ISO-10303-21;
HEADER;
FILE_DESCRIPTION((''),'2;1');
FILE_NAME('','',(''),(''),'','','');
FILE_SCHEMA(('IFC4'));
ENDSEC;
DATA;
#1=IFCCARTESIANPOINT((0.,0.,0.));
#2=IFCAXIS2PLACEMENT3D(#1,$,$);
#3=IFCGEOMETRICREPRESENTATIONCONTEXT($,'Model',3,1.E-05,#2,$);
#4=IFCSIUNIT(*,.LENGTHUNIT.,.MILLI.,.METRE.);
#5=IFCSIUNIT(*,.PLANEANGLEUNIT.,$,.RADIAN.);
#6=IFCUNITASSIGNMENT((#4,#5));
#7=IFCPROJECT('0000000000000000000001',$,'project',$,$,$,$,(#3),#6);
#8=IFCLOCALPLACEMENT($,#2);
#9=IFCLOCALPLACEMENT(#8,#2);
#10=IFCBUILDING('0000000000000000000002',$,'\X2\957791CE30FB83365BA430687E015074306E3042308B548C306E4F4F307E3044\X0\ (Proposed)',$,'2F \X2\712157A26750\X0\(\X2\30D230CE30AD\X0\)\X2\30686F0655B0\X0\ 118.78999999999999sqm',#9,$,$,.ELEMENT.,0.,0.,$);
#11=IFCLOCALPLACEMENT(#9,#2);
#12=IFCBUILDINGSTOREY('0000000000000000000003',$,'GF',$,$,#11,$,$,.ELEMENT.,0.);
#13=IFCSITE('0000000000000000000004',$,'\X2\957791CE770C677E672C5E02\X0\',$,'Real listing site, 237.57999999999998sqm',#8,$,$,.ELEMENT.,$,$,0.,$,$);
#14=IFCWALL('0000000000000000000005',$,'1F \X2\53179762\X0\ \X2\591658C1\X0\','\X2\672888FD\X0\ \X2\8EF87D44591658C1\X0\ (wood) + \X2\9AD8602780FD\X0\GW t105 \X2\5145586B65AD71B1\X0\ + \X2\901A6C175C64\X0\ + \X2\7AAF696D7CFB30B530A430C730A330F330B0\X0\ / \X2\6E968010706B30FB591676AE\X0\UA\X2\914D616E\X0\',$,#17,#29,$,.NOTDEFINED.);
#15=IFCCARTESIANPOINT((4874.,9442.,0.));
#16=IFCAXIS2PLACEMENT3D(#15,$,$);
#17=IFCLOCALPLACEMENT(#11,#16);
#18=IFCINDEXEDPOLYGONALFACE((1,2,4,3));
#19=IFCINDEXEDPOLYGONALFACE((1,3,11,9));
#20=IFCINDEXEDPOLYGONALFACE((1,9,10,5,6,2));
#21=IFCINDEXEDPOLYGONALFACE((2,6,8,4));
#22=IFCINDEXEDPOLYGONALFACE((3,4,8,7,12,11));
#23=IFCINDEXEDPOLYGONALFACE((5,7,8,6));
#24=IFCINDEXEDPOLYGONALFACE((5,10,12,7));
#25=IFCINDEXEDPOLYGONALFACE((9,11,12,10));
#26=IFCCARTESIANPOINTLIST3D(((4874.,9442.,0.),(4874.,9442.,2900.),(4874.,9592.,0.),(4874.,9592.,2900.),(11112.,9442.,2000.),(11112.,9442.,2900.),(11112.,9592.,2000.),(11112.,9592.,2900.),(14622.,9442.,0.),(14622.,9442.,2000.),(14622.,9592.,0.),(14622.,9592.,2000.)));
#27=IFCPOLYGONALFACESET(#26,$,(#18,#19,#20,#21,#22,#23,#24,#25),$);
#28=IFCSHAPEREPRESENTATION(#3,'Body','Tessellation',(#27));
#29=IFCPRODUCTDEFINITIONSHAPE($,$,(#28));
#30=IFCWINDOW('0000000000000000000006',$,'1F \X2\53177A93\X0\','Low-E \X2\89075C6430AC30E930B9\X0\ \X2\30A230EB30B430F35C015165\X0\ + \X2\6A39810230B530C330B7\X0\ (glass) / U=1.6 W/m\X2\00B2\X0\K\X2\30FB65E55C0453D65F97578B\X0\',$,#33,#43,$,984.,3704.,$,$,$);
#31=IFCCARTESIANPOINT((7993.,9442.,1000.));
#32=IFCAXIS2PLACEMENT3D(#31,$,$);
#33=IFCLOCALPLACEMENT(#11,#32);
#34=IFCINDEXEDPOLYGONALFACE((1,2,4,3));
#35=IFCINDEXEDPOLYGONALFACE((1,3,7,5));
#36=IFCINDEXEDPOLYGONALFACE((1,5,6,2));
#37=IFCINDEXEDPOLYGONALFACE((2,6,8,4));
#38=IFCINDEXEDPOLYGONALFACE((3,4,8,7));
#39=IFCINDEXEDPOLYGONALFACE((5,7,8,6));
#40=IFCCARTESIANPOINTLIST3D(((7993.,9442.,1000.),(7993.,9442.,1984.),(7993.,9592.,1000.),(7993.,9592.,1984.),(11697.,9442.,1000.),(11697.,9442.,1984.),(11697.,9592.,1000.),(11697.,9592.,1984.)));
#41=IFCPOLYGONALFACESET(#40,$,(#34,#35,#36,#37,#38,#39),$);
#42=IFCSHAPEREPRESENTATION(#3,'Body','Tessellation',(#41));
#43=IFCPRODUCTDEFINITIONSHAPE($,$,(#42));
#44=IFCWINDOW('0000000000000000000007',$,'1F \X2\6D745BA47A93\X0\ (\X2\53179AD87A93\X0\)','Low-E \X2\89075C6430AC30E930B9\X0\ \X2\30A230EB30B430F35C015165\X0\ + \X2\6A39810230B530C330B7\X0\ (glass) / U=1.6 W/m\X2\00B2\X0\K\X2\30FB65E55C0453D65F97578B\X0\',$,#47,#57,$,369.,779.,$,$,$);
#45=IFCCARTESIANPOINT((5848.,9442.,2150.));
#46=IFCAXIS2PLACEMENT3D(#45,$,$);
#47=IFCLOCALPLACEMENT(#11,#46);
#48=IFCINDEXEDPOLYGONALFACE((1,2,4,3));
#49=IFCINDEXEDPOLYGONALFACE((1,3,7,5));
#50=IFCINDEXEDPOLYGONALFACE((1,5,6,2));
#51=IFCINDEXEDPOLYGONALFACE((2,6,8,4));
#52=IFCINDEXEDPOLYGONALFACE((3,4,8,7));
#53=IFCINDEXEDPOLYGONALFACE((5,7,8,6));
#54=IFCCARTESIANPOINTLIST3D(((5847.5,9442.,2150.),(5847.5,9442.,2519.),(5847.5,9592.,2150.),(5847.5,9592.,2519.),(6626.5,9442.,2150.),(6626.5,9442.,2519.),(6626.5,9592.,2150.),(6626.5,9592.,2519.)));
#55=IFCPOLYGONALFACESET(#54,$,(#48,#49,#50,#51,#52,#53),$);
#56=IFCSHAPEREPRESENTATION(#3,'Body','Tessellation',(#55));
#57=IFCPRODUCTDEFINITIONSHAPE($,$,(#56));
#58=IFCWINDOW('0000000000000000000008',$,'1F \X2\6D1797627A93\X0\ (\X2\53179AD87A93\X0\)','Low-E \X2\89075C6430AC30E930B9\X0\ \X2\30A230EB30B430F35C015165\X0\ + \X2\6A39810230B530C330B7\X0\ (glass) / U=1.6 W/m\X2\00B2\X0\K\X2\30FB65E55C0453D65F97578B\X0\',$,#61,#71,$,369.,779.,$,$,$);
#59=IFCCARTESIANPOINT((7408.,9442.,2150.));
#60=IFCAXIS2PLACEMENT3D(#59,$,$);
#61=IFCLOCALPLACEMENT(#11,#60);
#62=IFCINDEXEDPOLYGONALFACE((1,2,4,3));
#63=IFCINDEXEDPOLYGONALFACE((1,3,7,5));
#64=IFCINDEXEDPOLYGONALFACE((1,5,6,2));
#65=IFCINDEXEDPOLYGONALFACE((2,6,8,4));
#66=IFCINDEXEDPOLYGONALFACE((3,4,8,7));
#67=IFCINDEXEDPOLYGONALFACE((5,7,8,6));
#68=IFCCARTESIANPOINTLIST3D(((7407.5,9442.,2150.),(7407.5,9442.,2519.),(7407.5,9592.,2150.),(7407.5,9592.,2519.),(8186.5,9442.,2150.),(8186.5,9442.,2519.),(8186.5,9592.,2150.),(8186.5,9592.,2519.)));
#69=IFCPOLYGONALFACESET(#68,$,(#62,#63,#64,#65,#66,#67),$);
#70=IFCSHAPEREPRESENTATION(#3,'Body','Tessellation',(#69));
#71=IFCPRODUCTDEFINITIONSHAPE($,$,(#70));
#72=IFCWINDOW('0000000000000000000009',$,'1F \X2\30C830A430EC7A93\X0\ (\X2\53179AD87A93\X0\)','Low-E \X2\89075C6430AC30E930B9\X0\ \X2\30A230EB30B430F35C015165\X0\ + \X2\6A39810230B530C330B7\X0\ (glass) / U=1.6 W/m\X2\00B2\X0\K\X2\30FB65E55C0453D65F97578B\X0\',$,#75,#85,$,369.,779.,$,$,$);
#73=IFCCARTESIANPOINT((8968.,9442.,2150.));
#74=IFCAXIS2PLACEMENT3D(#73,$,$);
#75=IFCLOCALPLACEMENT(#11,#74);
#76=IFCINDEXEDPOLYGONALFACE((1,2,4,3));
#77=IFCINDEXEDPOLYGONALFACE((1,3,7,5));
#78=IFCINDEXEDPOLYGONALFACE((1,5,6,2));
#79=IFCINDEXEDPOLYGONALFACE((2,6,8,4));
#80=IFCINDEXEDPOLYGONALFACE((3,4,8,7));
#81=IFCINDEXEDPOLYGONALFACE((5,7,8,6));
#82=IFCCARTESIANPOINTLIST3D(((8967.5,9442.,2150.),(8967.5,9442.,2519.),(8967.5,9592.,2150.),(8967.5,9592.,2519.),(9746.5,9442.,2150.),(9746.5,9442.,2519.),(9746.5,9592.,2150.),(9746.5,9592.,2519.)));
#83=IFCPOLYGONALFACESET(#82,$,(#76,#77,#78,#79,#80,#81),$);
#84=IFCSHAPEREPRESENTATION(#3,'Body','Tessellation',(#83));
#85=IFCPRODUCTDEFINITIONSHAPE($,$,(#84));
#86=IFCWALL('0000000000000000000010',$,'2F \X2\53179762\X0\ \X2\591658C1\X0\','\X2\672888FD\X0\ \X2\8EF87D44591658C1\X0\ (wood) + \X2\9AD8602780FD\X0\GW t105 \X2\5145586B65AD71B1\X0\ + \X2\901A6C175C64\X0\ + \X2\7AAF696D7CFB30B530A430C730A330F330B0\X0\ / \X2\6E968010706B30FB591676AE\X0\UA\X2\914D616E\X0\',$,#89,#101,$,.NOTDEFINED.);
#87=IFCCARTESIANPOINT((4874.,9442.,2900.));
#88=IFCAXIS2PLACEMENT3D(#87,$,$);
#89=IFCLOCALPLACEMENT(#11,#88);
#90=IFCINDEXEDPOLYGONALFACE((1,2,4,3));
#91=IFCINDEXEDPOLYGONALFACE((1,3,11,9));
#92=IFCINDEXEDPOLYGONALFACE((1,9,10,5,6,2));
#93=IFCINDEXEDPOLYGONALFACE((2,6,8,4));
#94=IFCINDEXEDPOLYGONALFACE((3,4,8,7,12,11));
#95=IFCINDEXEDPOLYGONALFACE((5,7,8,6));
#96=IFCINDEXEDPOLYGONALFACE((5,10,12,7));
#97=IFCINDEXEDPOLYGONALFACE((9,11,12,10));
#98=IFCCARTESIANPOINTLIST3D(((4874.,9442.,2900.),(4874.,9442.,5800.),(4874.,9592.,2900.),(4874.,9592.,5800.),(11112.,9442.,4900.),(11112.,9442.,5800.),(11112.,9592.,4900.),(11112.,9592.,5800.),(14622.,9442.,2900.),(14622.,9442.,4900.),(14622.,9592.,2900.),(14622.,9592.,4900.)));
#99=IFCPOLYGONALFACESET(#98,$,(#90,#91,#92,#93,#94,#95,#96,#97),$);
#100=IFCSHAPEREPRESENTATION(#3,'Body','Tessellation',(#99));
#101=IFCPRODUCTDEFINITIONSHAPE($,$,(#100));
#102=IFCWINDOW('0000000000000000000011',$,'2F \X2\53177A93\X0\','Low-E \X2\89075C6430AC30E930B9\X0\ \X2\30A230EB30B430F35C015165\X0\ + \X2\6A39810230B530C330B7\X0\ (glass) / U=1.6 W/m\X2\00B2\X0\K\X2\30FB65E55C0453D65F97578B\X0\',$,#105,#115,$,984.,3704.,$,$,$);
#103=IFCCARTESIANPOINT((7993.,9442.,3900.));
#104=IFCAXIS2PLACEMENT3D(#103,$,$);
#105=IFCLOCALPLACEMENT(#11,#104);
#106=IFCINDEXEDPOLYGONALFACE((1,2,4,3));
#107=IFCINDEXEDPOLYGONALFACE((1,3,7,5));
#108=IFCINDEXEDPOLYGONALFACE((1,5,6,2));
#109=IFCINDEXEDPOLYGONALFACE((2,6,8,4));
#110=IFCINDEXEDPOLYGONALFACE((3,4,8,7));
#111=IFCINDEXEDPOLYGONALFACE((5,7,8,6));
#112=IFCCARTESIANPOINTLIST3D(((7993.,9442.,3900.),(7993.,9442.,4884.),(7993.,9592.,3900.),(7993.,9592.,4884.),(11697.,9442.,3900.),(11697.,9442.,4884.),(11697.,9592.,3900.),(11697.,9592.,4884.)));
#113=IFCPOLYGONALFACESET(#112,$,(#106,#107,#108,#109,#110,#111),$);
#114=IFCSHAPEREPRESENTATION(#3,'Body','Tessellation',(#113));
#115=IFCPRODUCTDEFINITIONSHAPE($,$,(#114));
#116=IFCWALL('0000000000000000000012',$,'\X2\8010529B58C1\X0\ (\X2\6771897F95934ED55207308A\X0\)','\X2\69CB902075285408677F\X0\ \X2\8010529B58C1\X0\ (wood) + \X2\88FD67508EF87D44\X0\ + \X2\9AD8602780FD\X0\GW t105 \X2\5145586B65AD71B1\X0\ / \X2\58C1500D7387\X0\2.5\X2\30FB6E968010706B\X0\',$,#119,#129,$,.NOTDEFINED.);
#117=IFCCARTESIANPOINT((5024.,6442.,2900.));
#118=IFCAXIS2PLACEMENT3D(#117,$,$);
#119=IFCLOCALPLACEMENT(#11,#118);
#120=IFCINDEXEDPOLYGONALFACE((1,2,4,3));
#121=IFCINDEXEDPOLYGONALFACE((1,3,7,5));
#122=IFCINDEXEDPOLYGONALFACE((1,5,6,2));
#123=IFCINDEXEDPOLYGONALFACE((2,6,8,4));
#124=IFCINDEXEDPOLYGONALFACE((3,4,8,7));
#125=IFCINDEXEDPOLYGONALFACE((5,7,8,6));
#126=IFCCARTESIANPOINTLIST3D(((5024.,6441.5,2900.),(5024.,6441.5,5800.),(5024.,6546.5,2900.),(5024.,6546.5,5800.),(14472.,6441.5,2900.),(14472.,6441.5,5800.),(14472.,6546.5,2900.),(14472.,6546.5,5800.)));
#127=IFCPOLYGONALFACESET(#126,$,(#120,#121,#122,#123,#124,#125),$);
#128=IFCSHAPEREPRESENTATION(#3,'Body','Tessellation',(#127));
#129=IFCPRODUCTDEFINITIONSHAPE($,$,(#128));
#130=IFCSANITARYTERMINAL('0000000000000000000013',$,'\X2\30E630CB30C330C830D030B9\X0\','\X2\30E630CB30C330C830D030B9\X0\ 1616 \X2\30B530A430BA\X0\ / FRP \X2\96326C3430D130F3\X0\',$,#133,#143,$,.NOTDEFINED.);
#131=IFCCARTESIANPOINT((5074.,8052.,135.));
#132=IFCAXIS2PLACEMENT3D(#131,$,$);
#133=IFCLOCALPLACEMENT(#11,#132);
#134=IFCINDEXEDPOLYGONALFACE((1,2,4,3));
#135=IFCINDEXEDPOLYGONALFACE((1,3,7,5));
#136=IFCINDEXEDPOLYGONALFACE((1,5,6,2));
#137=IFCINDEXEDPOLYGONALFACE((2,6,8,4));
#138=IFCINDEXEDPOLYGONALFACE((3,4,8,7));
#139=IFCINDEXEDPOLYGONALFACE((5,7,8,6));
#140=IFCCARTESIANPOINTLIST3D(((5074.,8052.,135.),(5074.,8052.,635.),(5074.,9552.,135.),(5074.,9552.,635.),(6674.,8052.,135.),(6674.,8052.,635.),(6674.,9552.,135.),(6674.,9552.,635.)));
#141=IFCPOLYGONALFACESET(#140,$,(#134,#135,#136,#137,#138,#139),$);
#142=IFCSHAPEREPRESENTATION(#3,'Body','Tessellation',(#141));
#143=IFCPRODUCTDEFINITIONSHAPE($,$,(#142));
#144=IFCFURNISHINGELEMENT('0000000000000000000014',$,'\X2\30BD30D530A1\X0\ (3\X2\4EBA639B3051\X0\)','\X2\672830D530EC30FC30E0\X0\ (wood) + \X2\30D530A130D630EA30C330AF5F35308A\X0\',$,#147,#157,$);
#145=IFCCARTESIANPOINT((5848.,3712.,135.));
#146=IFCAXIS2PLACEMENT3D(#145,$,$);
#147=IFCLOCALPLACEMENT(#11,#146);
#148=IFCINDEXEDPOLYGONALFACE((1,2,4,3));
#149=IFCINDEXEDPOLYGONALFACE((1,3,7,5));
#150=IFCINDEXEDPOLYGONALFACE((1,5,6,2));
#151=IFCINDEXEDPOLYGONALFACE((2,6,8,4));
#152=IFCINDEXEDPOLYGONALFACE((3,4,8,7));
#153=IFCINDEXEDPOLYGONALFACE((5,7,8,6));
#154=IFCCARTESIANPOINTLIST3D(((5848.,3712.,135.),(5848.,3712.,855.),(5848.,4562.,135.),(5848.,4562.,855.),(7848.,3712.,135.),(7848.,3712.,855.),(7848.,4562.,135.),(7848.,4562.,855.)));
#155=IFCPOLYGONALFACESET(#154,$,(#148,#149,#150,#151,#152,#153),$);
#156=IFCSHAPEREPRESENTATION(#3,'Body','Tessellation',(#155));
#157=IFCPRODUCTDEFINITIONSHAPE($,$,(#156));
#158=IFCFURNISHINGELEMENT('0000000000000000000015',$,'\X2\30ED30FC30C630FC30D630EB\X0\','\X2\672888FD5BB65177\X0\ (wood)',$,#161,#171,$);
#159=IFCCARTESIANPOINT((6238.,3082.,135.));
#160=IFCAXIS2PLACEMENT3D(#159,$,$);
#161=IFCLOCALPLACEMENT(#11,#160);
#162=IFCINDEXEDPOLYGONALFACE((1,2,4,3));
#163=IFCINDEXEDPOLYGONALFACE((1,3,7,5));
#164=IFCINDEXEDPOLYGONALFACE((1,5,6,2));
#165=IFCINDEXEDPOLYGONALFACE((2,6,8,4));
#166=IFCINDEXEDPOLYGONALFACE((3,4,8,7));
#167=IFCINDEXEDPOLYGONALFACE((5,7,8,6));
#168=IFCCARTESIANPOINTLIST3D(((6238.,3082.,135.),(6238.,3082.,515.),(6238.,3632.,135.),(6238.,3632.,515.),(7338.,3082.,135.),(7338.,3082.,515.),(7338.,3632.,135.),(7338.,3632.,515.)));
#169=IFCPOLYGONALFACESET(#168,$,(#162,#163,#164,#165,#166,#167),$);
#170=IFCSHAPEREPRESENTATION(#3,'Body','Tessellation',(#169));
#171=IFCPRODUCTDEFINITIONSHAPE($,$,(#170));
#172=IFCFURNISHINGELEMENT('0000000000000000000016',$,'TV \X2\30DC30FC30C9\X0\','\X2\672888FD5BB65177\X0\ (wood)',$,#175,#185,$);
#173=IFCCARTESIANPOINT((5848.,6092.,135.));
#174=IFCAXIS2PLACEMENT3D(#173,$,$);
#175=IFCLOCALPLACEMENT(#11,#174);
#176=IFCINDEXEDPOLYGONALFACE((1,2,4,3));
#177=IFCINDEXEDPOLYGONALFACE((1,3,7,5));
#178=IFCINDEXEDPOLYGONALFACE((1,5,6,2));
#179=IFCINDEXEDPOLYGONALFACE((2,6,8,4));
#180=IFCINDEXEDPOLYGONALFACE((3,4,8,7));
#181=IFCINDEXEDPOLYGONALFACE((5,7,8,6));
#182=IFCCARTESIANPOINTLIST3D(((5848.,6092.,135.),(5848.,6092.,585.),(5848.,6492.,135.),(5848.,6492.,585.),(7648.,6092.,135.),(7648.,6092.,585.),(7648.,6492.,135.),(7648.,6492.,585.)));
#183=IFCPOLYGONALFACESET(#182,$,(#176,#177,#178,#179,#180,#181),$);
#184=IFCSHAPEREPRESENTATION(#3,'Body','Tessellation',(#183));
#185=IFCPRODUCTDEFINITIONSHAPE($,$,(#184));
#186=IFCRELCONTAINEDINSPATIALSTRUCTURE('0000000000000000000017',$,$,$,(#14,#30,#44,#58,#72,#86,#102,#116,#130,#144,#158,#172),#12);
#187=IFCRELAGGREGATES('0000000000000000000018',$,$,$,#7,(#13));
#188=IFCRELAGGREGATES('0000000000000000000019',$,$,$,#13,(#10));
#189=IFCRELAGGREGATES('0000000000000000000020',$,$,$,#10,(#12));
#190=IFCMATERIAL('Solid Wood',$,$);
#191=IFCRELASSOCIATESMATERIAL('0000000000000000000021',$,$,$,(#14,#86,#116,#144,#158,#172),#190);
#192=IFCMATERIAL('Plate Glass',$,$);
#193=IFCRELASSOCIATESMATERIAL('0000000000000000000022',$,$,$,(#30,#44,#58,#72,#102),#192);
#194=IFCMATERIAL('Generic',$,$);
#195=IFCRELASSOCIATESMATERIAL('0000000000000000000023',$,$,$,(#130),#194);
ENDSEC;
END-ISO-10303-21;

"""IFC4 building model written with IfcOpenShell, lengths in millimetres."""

from ifc_helpers import new_model, si_unit, frame, frame_2d, origin, place, context, project, spatial, rectangle, extrude, material, element, fill, save


model = new_model("IFC4")

# Units and contexts
model_context = context("Model", 3, precision=1e-05, world=origin())
ifc_project = project(units=[si_unit("LENGTHUNIT", "METRE", prefix="MILLI"), si_unit("PLANEANGLEUNIT", "RADIAN")], contexts=[model_context])

# Site, building, storey
site_placement = place(None, origin())
site = spatial("IfcSite", under=ifc_project, at=site_placement, Name="長野県松本市", ObjectType="Real listing site, 237.57999999999998sqm", CompositionType="ELEMENT", RefElevation=0.0)
building_placement = place(site_placement, origin())
building = spatial("IfcBuilding", under=site, at=building_placement, Name="長野・茶室と縁側のある和の住まい (Proposed)", ObjectType="2F 無垢材(ヒノキ)と漆喰 118.78999999999999sqm", CompositionType="ELEMENT", ElevationOfRefHeight=0.0, ElevationOfTerrain=0.0)
storey_placement = place(building_placement, origin())
storey = spatial("IfcBuildingStorey", under=building, at=storey_placement, Name="GF", CompositionType="ELEMENT", Elevation=0.0)

# Wall, openings, windows
ifc_material_1 = material(Name="Solid Wood")
wall_1_placement = place(storey_placement, frame((4874.0, 9442.0, 0.0)))
wall_1 = element("IfcWall", 1, at=wall_1_placement, inside=storey, material=ifc_material_1, Name="1F 北面 外壁", Description="木製 軸組外壁 (wood) + 高性能GW t105 充填断熱 + 通気層 + 窯業系サイディング / 準耐火・外皮UA配慮", PredefinedType="NOTDEFINED", context=model_context, shape_type="SweptSolid", body=[
    extrude(rectangle(XDim=9748.0, YDim=150.0, at=frame_2d((4874.0, 75.0))), frame((4874.0, 9442.0, 0.0)), (0.0, 0.0, 1.0), 2900.0),
])
opening_1_placement = place(storey_placement, frame((7993.0, 9442.0, 1000.0)))
opening_1 = element("IfcOpeningElement", 2, at=opening_1_placement, cuts=wall_1, PredefinedType="NOTDEFINED", context=model_context, shape_type="SweptSolid", body=[
    extrude(rectangle(XDim=3704.0, YDim=150.0, at=frame_2d((1852.0, 75.0))), frame((7993.0, 9442.0, 1000.0)), (0.0, 0.0, 1.0), 984.0),
])
opening_2_placement = place(storey_placement, frame((5848.0, 9442.0, 2150.0)))
opening_2 = element("IfcOpeningElement", 3, at=opening_2_placement, cuts=wall_1, PredefinedType="NOTDEFINED", context=model_context, shape_type="SweptSolid", body=[
    extrude(rectangle(XDim=779.0, YDim=150.0, at=frame_2d((389.0, 75.0))), frame((5848.0, 9442.0, 2150.0)), (0.0, 0.0, 1.0), 369.0),
])
opening_3_placement = place(storey_placement, frame((7408.0, 9442.0, 2150.0)))
opening_3 = element("IfcOpeningElement", 4, at=opening_3_placement, cuts=wall_1, PredefinedType="NOTDEFINED", context=model_context, shape_type="SweptSolid", body=[
    extrude(rectangle(XDim=779.0, YDim=150.0, at=frame_2d((389.0, 75.0))), frame((7408.0, 9442.0, 2150.0)), (0.0, 0.0, 1.0), 369.0),
])
opening_4_placement = place(storey_placement, frame((8968.0, 9442.0, 2150.0)))
opening_4 = element("IfcOpeningElement", 5, at=opening_4_placement, cuts=wall_1, PredefinedType="NOTDEFINED", context=model_context, shape_type="SweptSolid", body=[
    extrude(rectangle(XDim=779.0, YDim=150.0, at=frame_2d((389.0, 75.0))), frame((8968.0, 9442.0, 2150.0)), (0.0, 0.0, 1.0), 369.0),
])
ifc_material_2 = material(Name="Plate Glass")
window_1_placement = place(storey_placement, frame((7993.0, 9442.0, 1000.0)))
window_1 = element("IfcWindow", 6, at=window_1_placement, inside=storey, material=ifc_material_2, Name="1F 北窓", Description="Low-E 複層ガラス アルゴン封入 + 樹脂サッシ (glass) / U=1.6 W/m²K・日射取得型", OverallHeight=984.0, OverallWidth=3704.0, context=model_context, shape_type="SweptSolid", body=[
    extrude(rectangle(XDim=3704.0, YDim=150.0, at=frame_2d((1852.0, 75.0))), frame((7993.0, 9442.0, 1000.0)), (0.0, 0.0, 1.0), 984.0),
])
fill(opening_1, window_1)
window_2_placement = place(storey_placement, frame((5848.0, 9442.0, 2150.0)))
window_2 = element("IfcWindow", 7, at=window_2_placement, inside=storey, material=ifc_material_2, Name="1F 浴室窓 (北高窓)", Description="Low-E 複層ガラス アルゴン封入 + 樹脂サッシ (glass) / U=1.6 W/m²K・日射取得型", OverallHeight=369.0, OverallWidth=779.0, context=model_context, shape_type="SweptSolid", body=[
    extrude(rectangle(XDim=779.0, YDim=150.0, at=frame_2d((389.0, 75.0))), frame((5848.0, 9442.0, 2150.0)), (0.0, 0.0, 1.0), 369.0),
])
fill(opening_2, window_2)
window_3_placement = place(storey_placement, frame((7408.0, 9442.0, 2150.0)))
window_3 = element("IfcWindow", 8, at=window_3_placement, inside=storey, material=ifc_material_2, Name="1F 洗面窓 (北高窓)", Description="Low-E 複層ガラス アルゴン封入 + 樹脂サッシ (glass) / U=1.6 W/m²K・日射取得型", OverallHeight=369.0, OverallWidth=779.0, context=model_context, shape_type="SweptSolid", body=[
    extrude(rectangle(XDim=779.0, YDim=150.0, at=frame_2d((389.0, 75.0))), frame((7408.0, 9442.0, 2150.0)), (0.0, 0.0, 1.0), 369.0),
])
fill(opening_3, window_3)
window_4_placement = place(storey_placement, frame((8968.0, 9442.0, 2150.0)))
window_4 = element("IfcWindow", 9, at=window_4_placement, inside=storey, material=ifc_material_2, Name="1F トイレ窓 (北高窓)", Description="Low-E 複層ガラス アルゴン封入 + 樹脂サッシ (glass) / U=1.6 W/m²K・日射取得型", OverallHeight=369.0, OverallWidth=779.0, context=model_context, shape_type="SweptSolid", body=[
    extrude(rectangle(XDim=779.0, YDim=150.0, at=frame_2d((389.0, 75.0))), frame((8968.0, 9442.0, 2150.0)), (0.0, 0.0, 1.0), 369.0),
])
fill(opening_4, window_4)

# Wall, opening, window
wall_2_placement = place(storey_placement, frame((4874.0, 9442.0, 2900.0)))
wall_2 = element("IfcWall", 10, at=wall_2_placement, inside=storey, material=ifc_material_1, Name="2F 北面 外壁", Description="木製 軸組外壁 (wood) + 高性能GW t105 充填断熱 + 通気層 + 窯業系サイディング / 準耐火・外皮UA配慮", PredefinedType="NOTDEFINED", context=model_context, shape_type="SweptSolid", body=[
    extrude(rectangle(XDim=9748.0, YDim=150.0, at=frame_2d((4874.0, 75.0))), frame((4874.0, 9442.0, 2900.0)), (0.0, 0.0, 1.0), 2900.0),
])
opening_5_placement = place(storey_placement, frame((7993.0, 9442.0, 3900.0)))
opening_5 = element("IfcOpeningElement", 11, at=opening_5_placement, cuts=wall_2, PredefinedType="NOTDEFINED", context=model_context, shape_type="SweptSolid", body=[
    extrude(rectangle(XDim=3704.0, YDim=150.0, at=frame_2d((1852.0, 75.0))), frame((7993.0, 9442.0, 3900.0)), (0.0, 0.0, 1.0), 984.0),
])
window_5_placement = place(storey_placement, frame((7993.0, 9442.0, 3900.0)))
window_5 = element("IfcWindow", 12, at=window_5_placement, inside=storey, material=ifc_material_2, Name="2F 北窓", Description="Low-E 複層ガラス アルゴン封入 + 樹脂サッシ (glass) / U=1.6 W/m²K・日射取得型", OverallHeight=984.0, OverallWidth=3704.0, context=model_context, shape_type="SweptSolid", body=[
    extrude(rectangle(XDim=3704.0, YDim=150.0, at=frame_2d((1852.0, 75.0))), frame((7993.0, 9442.0, 3900.0)), (0.0, 0.0, 1.0), 984.0),
])
fill(opening_5, window_5)

# Wall
wall_3_placement = place(storey_placement, frame((5024.0, 6442.0, 2900.0)))
element("IfcWall", 13, at=wall_3_placement, inside=storey, material=ifc_material_1, Name="耐力壁 (東西間仕切り)", Description="構造用合板 耐力壁 (wood) + 製材軸組 + 高性能GW t105 充填断熱 / 壁倍率2.5・準耐火", PredefinedType="NOTDEFINED", context=model_context, shape_type="SweptSolid", body=[
    extrude(rectangle(XDim=9448.0, YDim=105.0, at=frame_2d((4724.0, 52.0))), frame((5024.0, 6442.0, 2900.0)), (0.0, 0.0, 1.0), 2900.0),
])

# Sanitary terminal
ifc_material_3 = material(Name="Generic")
sanitary_terminal_placement = place(storey_placement, frame((5074.0, 8052.0, 135.0)))
element("IfcSanitaryTerminal", 14, at=sanitary_terminal_placement, inside=storey, material=ifc_material_3, Name="ユニットバス", Description="ユニットバス 1616 サイズ / FRP 防水パン", PredefinedType="NOTDEFINED", context=model_context, shape_type="SweptSolid", body=[
    extrude(rectangle(XDim=1600.0, YDim=1500.0, at=frame_2d((800.0, 750.0))), frame((5074.0, 8052.0, 135.0)), (0.0, 0.0, 1.0), 500.0),
])

# Furnishing elements
furnishing_1_placement = place(storey_placement, frame((5848.0, 3712.0, 135.0)))
element("IfcFurnishingElement", 15, at=furnishing_1_placement, inside=storey, material=ifc_material_1, Name="ソファ (3人掛け)", Description="木フレーム (wood) + ファブリック張り", context=model_context, shape_type="SweptSolid", body=[
    extrude(rectangle(XDim=2000.0, YDim=850.0, at=frame_2d((1000.0, 425.0))), frame((5848.0, 3712.0, 135.0)), (0.0, 0.0, 1.0), 720.0),
])
furnishing_2_placement = place(storey_placement, frame((6238.0, 3082.0, 135.0)))
element("IfcFurnishingElement", 16, at=furnishing_2_placement, inside=storey, material=ifc_material_1, Name="ローテーブル", Description="木製家具 (wood)", context=model_context, shape_type="SweptSolid", body=[
    extrude(rectangle(XDim=1100.0, YDim=550.0, at=frame_2d((550.0, 275.0))), frame((6238.0, 3082.0, 135.0)), (0.0, 0.0, 1.0), 380.0),
])
furnishing_3_placement = place(storey_placement, frame((5848.0, 6092.0, 135.0)))
element("IfcFurnishingElement", 17, at=furnishing_3_placement, inside=storey, material=ifc_material_1, Name="TV ボード", Description="木製家具 (wood)", context=model_context, shape_type="SweptSolid", body=[
    extrude(rectangle(XDim=1800.0, YDim=400.0, at=frame_2d((900.0, 200.0))), frame((5848.0, 6092.0, 135.0)), (0.0, 0.0, 1.0), 450.0),
])

save(model, "model.ifc")
